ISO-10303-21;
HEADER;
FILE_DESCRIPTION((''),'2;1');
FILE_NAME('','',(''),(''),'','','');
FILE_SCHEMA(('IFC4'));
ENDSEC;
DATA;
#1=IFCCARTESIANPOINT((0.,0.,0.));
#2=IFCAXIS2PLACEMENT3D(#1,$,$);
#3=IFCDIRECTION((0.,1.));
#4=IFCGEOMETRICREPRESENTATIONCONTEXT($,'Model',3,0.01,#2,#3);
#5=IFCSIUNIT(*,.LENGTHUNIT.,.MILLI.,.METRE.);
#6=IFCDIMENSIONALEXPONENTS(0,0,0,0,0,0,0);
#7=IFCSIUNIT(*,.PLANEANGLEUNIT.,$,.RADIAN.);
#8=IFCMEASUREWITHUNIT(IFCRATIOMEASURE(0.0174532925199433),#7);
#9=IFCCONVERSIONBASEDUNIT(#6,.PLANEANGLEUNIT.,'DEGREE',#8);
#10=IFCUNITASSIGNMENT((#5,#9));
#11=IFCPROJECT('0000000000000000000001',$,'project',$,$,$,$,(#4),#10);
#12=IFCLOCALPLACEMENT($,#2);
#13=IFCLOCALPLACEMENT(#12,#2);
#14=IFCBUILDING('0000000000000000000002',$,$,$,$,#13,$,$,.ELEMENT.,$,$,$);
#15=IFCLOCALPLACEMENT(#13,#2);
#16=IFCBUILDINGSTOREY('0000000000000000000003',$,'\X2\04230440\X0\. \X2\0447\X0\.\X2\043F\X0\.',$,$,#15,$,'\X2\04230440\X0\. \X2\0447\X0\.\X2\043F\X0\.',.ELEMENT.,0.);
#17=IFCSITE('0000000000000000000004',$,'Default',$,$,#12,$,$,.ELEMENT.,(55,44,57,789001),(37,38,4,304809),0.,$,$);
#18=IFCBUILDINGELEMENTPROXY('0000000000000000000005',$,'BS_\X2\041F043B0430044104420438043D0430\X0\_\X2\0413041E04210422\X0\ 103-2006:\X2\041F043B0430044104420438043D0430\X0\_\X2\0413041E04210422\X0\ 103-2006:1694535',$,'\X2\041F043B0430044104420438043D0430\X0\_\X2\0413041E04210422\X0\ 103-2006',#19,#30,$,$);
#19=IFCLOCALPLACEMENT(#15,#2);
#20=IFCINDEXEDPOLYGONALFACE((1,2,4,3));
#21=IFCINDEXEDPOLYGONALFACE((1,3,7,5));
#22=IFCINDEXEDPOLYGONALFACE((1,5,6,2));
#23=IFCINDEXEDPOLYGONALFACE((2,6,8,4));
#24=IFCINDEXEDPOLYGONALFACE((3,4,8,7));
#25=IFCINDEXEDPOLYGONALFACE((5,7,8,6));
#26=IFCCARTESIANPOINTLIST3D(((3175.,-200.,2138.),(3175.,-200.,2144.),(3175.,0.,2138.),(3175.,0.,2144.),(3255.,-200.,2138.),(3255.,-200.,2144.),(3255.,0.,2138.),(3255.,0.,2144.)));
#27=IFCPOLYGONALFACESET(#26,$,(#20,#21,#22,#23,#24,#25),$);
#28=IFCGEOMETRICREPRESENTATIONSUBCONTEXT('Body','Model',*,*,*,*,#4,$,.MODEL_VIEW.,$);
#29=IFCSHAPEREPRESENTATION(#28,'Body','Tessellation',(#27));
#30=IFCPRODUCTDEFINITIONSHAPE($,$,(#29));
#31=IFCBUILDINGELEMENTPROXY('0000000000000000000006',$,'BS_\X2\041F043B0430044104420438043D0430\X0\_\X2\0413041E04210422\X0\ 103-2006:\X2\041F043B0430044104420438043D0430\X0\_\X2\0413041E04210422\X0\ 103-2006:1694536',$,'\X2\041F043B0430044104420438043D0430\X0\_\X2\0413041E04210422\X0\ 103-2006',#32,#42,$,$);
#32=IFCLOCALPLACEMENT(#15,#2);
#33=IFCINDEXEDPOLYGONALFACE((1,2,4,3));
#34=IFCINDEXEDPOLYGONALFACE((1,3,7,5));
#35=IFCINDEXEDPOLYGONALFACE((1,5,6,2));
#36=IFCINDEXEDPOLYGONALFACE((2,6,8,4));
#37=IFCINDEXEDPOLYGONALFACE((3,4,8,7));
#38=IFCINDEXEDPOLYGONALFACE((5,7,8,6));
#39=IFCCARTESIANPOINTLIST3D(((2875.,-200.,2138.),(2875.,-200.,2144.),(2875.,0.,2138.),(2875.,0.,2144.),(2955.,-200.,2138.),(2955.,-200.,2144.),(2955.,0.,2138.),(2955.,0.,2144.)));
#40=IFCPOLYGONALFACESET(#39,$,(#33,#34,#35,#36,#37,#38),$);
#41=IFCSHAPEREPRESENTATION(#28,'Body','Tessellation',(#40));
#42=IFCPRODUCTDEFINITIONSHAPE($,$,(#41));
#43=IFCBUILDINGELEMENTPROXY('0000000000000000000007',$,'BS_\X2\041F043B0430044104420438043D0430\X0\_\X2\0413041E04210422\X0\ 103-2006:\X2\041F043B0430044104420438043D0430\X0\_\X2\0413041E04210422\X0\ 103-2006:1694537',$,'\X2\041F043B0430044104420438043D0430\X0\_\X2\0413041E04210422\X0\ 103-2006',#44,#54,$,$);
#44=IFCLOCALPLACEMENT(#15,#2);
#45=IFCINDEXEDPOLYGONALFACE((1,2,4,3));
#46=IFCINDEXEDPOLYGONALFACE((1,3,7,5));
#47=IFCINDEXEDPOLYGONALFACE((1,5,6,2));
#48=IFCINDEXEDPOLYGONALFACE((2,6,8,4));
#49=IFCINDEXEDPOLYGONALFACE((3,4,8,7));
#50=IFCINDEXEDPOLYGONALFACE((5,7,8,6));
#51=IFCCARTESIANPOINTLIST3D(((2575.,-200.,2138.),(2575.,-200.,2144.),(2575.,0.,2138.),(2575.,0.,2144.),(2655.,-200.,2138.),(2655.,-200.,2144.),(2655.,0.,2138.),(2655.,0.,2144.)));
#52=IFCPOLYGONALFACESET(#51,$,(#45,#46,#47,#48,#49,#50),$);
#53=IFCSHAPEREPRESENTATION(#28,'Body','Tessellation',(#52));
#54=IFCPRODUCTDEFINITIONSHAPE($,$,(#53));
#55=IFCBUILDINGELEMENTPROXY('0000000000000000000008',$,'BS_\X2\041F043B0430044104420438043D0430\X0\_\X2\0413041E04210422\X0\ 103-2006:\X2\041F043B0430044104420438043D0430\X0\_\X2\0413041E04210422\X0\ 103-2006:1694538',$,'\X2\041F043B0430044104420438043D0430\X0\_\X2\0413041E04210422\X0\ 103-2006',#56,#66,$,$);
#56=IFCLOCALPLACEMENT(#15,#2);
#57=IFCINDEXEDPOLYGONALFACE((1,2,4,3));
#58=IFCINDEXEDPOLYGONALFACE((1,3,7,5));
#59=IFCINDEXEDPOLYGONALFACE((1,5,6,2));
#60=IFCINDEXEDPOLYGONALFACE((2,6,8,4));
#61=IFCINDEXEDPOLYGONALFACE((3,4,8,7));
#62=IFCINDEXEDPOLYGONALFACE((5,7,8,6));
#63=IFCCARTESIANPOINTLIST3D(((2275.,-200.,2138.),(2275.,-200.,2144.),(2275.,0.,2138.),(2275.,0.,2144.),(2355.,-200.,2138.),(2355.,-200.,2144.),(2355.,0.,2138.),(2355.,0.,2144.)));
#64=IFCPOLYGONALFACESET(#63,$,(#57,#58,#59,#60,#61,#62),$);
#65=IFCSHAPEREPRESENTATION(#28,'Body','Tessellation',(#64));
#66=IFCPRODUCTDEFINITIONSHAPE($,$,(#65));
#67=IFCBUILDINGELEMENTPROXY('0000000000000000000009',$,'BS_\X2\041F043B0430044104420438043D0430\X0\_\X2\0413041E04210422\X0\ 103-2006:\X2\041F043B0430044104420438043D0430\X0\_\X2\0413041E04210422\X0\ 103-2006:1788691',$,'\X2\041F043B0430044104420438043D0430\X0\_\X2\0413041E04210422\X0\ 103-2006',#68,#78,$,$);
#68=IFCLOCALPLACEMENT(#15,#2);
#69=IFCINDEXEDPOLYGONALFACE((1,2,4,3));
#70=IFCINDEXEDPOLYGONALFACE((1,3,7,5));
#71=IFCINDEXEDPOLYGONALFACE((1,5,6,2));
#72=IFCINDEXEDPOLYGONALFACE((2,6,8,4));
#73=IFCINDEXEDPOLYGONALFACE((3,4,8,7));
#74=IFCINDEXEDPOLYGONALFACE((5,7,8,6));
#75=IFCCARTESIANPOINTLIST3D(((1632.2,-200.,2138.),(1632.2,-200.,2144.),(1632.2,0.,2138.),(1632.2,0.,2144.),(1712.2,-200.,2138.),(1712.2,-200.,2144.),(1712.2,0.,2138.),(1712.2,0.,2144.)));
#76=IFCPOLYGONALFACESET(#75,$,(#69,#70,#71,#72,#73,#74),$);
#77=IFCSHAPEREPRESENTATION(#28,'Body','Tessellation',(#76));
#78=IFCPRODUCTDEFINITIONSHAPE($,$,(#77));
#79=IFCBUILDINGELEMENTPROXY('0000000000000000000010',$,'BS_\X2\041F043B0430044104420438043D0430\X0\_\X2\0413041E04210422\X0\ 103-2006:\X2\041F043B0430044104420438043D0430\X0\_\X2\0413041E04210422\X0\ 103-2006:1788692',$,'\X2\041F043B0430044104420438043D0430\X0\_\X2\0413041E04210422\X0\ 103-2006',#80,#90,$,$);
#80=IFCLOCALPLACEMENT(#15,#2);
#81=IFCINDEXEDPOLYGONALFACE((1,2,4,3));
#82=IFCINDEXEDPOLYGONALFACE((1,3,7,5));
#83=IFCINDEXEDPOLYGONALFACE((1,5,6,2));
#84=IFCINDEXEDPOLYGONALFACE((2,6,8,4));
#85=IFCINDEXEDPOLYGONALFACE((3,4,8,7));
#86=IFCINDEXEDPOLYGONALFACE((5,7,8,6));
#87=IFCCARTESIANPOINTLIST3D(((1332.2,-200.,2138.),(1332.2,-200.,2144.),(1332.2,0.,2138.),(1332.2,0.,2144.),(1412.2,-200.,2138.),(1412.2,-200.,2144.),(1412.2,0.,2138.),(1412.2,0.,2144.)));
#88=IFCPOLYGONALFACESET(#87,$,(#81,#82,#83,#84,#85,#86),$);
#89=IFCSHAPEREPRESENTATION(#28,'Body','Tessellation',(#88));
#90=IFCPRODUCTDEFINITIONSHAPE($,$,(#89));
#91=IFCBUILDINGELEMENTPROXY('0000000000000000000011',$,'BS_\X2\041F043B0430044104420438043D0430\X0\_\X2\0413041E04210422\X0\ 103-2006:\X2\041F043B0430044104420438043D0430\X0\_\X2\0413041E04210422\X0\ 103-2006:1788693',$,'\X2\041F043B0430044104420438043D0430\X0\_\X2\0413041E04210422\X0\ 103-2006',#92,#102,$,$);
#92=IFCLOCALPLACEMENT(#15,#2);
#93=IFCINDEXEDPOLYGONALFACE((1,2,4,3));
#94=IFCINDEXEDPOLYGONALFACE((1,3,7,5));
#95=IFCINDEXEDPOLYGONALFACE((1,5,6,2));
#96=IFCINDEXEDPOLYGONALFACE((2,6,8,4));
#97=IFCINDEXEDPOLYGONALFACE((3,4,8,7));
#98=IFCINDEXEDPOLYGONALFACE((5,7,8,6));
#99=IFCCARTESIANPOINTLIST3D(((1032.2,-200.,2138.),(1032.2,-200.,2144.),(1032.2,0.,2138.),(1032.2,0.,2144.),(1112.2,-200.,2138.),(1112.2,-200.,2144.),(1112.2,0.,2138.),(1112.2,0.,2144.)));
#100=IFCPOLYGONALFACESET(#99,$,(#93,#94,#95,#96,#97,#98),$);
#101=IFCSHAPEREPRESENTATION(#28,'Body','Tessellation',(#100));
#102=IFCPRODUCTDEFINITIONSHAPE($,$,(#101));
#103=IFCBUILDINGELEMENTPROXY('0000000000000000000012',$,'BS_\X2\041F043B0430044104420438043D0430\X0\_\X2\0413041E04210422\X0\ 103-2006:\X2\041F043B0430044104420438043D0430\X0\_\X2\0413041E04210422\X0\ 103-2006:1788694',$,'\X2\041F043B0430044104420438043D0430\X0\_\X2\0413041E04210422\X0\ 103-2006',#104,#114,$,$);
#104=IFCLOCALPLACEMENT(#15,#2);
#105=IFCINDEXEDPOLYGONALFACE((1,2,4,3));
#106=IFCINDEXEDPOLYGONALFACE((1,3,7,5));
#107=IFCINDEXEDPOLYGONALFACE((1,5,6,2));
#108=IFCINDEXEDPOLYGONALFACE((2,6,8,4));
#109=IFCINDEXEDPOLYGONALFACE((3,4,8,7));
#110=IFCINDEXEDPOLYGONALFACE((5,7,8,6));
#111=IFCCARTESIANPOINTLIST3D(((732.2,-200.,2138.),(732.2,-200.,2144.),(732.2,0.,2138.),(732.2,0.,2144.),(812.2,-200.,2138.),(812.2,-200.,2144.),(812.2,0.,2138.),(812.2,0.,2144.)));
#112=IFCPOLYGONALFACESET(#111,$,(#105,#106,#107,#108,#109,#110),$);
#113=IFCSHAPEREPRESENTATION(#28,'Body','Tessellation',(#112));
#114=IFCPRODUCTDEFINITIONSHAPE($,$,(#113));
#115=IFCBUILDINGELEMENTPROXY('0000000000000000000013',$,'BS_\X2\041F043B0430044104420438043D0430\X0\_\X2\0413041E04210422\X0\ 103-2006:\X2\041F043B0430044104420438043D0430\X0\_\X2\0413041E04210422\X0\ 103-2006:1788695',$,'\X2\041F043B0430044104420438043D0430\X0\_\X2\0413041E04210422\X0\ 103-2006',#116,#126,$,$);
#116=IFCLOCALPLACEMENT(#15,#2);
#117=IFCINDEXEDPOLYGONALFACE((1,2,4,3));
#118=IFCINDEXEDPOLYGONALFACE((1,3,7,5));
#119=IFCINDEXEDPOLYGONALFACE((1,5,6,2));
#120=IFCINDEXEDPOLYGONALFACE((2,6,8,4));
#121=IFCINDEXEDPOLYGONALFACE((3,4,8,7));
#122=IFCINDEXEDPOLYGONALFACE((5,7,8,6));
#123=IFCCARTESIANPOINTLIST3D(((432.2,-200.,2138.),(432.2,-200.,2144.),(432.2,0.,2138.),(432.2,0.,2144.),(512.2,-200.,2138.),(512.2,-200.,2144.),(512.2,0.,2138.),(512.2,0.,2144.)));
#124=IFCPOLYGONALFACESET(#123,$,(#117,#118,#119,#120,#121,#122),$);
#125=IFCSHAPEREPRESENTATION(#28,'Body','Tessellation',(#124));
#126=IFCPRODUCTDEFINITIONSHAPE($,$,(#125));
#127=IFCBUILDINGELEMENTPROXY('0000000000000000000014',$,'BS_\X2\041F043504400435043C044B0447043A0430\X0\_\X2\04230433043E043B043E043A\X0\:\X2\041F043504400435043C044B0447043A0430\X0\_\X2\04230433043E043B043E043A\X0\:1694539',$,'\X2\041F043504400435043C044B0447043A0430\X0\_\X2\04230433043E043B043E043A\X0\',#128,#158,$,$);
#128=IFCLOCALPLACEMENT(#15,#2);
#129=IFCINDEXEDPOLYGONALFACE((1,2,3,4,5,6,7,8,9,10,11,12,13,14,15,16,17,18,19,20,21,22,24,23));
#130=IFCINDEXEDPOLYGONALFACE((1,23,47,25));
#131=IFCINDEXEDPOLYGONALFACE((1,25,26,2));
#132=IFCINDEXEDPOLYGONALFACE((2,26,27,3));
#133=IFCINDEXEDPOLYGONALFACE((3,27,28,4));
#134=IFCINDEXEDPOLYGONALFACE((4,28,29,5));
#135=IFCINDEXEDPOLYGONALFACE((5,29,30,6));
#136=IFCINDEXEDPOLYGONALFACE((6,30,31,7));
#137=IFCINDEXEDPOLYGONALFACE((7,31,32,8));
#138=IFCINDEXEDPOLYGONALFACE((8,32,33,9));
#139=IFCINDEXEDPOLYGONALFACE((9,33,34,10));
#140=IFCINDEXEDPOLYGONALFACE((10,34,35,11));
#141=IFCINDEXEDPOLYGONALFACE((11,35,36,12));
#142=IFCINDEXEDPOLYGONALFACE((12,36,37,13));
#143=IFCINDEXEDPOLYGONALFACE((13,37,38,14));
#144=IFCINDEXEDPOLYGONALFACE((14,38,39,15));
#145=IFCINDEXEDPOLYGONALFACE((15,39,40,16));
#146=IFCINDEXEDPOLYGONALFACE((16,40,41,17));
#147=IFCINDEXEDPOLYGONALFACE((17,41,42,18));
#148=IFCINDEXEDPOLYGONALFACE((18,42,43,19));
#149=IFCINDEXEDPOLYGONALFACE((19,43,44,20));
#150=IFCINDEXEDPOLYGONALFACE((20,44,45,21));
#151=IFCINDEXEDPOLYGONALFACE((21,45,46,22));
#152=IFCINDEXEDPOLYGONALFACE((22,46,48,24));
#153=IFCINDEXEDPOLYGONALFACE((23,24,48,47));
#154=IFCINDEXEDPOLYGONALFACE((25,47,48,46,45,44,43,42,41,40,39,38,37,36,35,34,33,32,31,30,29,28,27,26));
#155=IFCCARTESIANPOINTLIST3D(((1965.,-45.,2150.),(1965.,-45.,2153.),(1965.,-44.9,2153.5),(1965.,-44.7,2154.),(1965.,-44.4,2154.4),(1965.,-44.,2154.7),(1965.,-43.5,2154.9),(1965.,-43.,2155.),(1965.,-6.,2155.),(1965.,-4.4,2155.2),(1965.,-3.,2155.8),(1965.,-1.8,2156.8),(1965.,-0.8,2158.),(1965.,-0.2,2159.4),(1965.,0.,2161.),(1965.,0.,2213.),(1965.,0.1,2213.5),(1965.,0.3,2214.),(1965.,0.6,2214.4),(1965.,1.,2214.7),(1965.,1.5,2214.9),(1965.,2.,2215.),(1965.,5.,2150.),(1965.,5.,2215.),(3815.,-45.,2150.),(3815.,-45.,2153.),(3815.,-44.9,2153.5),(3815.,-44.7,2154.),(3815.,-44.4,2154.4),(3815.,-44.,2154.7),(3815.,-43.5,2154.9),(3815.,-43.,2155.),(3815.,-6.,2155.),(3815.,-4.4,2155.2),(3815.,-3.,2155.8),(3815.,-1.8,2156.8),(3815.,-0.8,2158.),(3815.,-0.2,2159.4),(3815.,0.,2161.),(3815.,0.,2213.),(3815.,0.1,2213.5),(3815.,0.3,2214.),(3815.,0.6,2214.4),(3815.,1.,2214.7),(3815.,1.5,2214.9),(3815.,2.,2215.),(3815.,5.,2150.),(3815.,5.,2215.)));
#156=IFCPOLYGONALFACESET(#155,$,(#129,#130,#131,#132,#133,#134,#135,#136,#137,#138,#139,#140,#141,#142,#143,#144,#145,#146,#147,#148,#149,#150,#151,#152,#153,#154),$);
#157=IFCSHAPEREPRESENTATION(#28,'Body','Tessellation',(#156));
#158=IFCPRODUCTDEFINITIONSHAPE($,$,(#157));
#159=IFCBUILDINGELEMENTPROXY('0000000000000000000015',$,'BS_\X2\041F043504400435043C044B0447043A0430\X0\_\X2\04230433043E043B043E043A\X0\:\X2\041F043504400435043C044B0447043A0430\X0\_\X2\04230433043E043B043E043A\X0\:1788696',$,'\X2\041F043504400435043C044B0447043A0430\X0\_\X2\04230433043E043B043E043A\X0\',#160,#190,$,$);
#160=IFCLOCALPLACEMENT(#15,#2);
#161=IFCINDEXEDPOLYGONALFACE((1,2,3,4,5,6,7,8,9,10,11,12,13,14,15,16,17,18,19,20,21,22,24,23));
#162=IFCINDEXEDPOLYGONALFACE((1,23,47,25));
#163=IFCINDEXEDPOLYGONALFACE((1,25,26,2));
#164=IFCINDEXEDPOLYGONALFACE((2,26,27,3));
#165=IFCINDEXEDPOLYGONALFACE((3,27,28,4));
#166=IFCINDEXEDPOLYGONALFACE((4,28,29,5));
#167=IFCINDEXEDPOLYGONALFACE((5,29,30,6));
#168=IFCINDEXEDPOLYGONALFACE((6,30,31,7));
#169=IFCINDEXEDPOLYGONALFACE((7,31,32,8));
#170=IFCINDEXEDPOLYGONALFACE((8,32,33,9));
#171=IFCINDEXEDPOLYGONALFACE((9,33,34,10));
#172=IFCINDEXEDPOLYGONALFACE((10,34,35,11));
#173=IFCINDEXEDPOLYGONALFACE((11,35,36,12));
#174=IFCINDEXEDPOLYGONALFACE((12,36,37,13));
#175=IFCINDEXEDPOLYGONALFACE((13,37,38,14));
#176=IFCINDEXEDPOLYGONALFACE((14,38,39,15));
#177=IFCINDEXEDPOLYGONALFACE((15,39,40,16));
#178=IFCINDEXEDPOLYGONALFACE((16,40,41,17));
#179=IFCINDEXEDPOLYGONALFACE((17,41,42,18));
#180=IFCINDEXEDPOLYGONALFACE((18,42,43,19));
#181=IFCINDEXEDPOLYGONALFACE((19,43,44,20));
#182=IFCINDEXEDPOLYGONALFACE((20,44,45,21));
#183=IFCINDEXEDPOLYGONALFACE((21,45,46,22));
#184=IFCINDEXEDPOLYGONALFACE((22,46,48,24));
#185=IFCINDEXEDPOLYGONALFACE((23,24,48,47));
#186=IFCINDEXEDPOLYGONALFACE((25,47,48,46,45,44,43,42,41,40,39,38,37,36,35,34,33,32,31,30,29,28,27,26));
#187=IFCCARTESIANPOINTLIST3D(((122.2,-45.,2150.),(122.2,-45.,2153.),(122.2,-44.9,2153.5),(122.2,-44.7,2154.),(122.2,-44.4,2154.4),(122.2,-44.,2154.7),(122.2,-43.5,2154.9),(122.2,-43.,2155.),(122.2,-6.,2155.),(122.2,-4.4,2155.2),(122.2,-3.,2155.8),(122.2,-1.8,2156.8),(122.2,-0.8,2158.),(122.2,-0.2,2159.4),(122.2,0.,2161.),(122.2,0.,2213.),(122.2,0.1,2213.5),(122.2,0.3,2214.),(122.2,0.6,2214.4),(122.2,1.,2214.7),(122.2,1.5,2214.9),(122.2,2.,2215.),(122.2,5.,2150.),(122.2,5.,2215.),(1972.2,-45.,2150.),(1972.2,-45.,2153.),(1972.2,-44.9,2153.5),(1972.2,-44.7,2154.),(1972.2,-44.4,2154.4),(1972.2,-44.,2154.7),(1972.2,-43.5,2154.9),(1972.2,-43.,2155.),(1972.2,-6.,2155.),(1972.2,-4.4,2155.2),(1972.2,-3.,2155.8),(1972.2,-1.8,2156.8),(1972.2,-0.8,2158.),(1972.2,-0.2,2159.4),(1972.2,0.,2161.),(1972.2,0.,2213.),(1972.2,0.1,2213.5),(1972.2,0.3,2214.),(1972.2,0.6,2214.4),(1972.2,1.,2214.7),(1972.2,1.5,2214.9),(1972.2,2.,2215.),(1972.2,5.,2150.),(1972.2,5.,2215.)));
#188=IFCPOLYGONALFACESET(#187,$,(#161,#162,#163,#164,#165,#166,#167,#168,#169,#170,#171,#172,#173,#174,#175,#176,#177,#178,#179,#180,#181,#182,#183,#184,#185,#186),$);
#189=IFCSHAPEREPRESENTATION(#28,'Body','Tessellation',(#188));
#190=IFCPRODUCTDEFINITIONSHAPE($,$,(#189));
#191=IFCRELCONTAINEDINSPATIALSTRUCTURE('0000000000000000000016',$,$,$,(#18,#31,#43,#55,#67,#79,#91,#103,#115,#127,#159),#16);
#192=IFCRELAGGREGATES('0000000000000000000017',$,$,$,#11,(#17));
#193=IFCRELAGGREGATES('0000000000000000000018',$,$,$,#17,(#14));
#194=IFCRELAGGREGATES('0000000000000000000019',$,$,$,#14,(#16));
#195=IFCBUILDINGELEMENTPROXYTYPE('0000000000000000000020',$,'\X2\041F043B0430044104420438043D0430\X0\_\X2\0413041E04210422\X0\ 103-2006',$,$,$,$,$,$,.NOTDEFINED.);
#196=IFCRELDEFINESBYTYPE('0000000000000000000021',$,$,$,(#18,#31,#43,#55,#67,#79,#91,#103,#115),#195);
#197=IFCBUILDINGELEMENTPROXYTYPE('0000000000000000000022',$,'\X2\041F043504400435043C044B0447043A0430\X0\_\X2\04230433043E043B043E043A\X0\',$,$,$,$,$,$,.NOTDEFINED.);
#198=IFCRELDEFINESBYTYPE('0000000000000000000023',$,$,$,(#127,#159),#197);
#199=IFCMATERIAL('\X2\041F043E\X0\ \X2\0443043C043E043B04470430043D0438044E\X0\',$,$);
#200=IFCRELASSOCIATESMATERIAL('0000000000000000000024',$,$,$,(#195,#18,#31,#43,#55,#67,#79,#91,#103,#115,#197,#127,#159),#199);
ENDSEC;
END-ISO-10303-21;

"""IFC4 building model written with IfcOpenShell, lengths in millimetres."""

from ifc_helpers import new_model, entity, si_unit, converted_unit, direction, frame, frame_2d, origin, origin_2d_with_axis, place, context, subcontext, project, spatial, polyline, circle_curve, parameter, trimmed, segment, composite_curve, rectangle, outline, extrude, source, transform, mapped, material, type_object, type_shapes, element, save


model = new_model("IFC4")

# Units and contexts
model_context = context("Model", 3, precision=0.01, world=origin(), true_north=direction((0.0, 1.0)))
body_context = subcontext(model_context, "Body", "Model", "MODEL_VIEW")
ifc_project = project(units=[si_unit("LENGTHUNIT", "METRE", prefix="MILLI"), converted_unit("PLANEANGLEUNIT", "DEGREE", entity("IfcRatioMeasure", 0.0174532925199433), si_unit("PLANEANGLEUNIT", "RADIAN"), dimensions=[0, 0, 0, 0, 0, 0, 0])], contexts=[model_context])

# Site, building, storey
site_placement = place(None, origin())
site = spatial("IfcSite", under=ifc_project, at=site_placement, Name="Default", CompositionType="ELEMENT", RefLatitude=(55, 44, 57, 789001), RefLongitude=(37, 38, 4, 304809), RefElevation=0.0)
building_placement = place(site_placement, origin())
building = spatial("IfcBuilding", under=site, at=building_placement, CompositionType="ELEMENT")
storey_placement = place(building_placement, origin())
storey = spatial("IfcBuildingStorey", under=building, at=storey_placement, Name="Ур. ч.п.", LongName="Ур. ч.п.", CompositionType="ELEMENT", Elevation=0.0)

# Building element proxies
ifc_material_1 = material(Name="По умолчанию")
building_element_proxy_type_1 = type_object("IfcBuildingElementProxyType", Name="Пластина_ГОСТ 103-2006", material=ifc_material_1)
shared_shape_1 = source(origin(), body_context, "Body", "SweptSolid", [
    extrude(rectangle(XDim=200.0, YDim=80.0, at=origin_2d_with_axis()), frame((0.0, 0.0, 0.0), z_axis=(0.0, 0.0, 1.0), x_axis=(-1.0, 0.0, 0.0)), (0.0, 0.0, 1.0), 6.0),
])
type_shapes(building_element_proxy_type_1, [shared_shape_1])
for number, where, z_axis, x_axis, name in (
    (1, (3215.0, -100.0, 2138.0), (0.0, 0.0, 1.0), (0.0, 1.0, 0.0), "BS_Пластина_ГОСТ 103-2006:Пластина_ГОСТ 103-2006:1694535"),
    (2, (2915.0, -100.0, 2138.0), (0.0, 0.0, 1.0), (0.0, 1.0, 0.0), "BS_Пластина_ГОСТ 103-2006:Пластина_ГОСТ 103-2006:1694536"),
    (3, (2615.0, -100.0, 2138.0), (0.0, 0.0, 1.0), (0.0, 1.0, 0.0), "BS_Пластина_ГОСТ 103-2006:Пластина_ГОСТ 103-2006:1694537"),
    (4, (2315.0, -100.0, 2138.0), (0.0, 0.0, 1.0), (0.0, 1.0, 0.0), "BS_Пластина_ГОСТ 103-2006:Пластина_ГОСТ 103-2006:1694538"),
    (5, (1672.2, -100.0, 2138.0), (0.0, 0.0, 1.0), (0.0, 1.0, 0.0), "BS_Пластина_ГОСТ 103-2006:Пластина_ГОСТ 103-2006:1788691"),
    (6, (1372.2, -100.0, 2138.0), (0.0, 0.0, 1.0), (0.0, 1.0, 0.0), "BS_Пластина_ГОСТ 103-2006:Пластина_ГОСТ 103-2006:1788692"),
    (7, (1072.2, -100.0, 2138.0), (0.0, 0.0, 1.0), (0.0, 1.0, 0.0), "BS_Пластина_ГОСТ 103-2006:Пластина_ГОСТ 103-2006:1788693"),
    (8, (772.2, -100.0, 2138.0), (0.0, 0.0, 1.0), (0.0, 1.0, 0.0), "BS_Пластина_ГОСТ 103-2006:Пластина_ГОСТ 103-2006:1788694"),
    (9, (472.2, -100.0, 2138.0), (0.0, 0.0, 1.0), (0.0, 1.0, 0.0), "BS_Пластина_ГОСТ 103-2006:Пластина_ГОСТ 103-2006:1788695"),
):
    element("IfcBuildingElementProxy", number, at=place(storey_placement, frame(where, z_axis=z_axis, x_axis=x_axis)), inside=storey, type_object=building_element_proxy_type_1, material=ifc_material_1, Name=name, ObjectType="Пластина_ГОСТ 103-2006", context=body_context, shape_type="MappedRepresentation", body=[
        mapped(shared_shape_1, transform((0.0, 0.0, 0.0), scale=1.0)),
    ])
building_element_proxy_type_2 = type_object("IfcBuildingElementProxyType", Name="Перемычка_Уголок", material=ifc_material_1)
shared_shape_2 = source(origin(), body_context, "Body", "SweptSolid", [
    extrude(outline(composite_curve([segment(polyline([(-24.1, -19.1), (40.9, -19.1)]), True, "CONTINUOUS"), segment(polyline([(40.9, -19.1), (40.9, -16.1)]), True, "CONTINUOUS"), segment(trimmed(circle_curve(frame_2d((38.9, -16.1), x_axis=(0.0, 1.0)), 2.0), [parameter(270.0)], [parameter(0.0)], True, "PARAMETER"), True, "CONTINUOUS"), segment(polyline([(38.9, -14.1), (-13.1, -14.1)]), True, "CONTINUOUS"), segment(trimmed(circle_curve(frame_2d((-13.1, -8.1), x_axis=(0.0, 1.0)), 6.0), [parameter(90.0)], [parameter(180.0)], True, "PARAMETER"), False, "CONTINUOUS"), segment(polyline([(-19.1, -8.1), (-19.1, 28.9)]), True, "CONTINUOUS"), segment(trimmed(circle_curve(frame_2d((-21.1, 28.9), x_axis=(0.0, 1.0)), 2.0), [parameter(270.0)], [parameter(0.0)], True, "PARAMETER"), True, "CONTINUOUS"), segment(polyline([(-21.1, 30.9), (-24.1, 30.9)]), True, "CONTINUOUS"), segment(polyline([(-24.1, 30.9), (-24.1, -19.1)]), True, "CONTINUOUS")], self_intersect=False)), frame((0.0, 32.5, 24.1), z_axis=(1.0, 0.0, 0.0), x_axis=(0.0, 0.0, 1.0)), (0.0, 0.0, 1.0), 1850.0),
])
type_shapes(building_element_proxy_type_2, [shared_shape_2])
for number, where, name in (
    (10, (1965.0, -46.6, 2150.0), "BS_Перемычка_Уголок:Перемычка_Уголок:1694539"),
    (11, (122.2, -46.6, 2150.0), "BS_Перемычка_Уголок:Перемычка_Уголок:1788696"),
):
    element("IfcBuildingElementProxy", number, at=place(storey_placement, frame(where)), inside=storey, type_object=building_element_proxy_type_2, material=ifc_material_1, Name=name, ObjectType="Перемычка_Уголок", context=body_context, shape_type="MappedRepresentation", body=[
        mapped(shared_shape_2, transform((0.0, 0.0, 0.0), scale=1.0)),
    ])

save(model, "model.ifc")
